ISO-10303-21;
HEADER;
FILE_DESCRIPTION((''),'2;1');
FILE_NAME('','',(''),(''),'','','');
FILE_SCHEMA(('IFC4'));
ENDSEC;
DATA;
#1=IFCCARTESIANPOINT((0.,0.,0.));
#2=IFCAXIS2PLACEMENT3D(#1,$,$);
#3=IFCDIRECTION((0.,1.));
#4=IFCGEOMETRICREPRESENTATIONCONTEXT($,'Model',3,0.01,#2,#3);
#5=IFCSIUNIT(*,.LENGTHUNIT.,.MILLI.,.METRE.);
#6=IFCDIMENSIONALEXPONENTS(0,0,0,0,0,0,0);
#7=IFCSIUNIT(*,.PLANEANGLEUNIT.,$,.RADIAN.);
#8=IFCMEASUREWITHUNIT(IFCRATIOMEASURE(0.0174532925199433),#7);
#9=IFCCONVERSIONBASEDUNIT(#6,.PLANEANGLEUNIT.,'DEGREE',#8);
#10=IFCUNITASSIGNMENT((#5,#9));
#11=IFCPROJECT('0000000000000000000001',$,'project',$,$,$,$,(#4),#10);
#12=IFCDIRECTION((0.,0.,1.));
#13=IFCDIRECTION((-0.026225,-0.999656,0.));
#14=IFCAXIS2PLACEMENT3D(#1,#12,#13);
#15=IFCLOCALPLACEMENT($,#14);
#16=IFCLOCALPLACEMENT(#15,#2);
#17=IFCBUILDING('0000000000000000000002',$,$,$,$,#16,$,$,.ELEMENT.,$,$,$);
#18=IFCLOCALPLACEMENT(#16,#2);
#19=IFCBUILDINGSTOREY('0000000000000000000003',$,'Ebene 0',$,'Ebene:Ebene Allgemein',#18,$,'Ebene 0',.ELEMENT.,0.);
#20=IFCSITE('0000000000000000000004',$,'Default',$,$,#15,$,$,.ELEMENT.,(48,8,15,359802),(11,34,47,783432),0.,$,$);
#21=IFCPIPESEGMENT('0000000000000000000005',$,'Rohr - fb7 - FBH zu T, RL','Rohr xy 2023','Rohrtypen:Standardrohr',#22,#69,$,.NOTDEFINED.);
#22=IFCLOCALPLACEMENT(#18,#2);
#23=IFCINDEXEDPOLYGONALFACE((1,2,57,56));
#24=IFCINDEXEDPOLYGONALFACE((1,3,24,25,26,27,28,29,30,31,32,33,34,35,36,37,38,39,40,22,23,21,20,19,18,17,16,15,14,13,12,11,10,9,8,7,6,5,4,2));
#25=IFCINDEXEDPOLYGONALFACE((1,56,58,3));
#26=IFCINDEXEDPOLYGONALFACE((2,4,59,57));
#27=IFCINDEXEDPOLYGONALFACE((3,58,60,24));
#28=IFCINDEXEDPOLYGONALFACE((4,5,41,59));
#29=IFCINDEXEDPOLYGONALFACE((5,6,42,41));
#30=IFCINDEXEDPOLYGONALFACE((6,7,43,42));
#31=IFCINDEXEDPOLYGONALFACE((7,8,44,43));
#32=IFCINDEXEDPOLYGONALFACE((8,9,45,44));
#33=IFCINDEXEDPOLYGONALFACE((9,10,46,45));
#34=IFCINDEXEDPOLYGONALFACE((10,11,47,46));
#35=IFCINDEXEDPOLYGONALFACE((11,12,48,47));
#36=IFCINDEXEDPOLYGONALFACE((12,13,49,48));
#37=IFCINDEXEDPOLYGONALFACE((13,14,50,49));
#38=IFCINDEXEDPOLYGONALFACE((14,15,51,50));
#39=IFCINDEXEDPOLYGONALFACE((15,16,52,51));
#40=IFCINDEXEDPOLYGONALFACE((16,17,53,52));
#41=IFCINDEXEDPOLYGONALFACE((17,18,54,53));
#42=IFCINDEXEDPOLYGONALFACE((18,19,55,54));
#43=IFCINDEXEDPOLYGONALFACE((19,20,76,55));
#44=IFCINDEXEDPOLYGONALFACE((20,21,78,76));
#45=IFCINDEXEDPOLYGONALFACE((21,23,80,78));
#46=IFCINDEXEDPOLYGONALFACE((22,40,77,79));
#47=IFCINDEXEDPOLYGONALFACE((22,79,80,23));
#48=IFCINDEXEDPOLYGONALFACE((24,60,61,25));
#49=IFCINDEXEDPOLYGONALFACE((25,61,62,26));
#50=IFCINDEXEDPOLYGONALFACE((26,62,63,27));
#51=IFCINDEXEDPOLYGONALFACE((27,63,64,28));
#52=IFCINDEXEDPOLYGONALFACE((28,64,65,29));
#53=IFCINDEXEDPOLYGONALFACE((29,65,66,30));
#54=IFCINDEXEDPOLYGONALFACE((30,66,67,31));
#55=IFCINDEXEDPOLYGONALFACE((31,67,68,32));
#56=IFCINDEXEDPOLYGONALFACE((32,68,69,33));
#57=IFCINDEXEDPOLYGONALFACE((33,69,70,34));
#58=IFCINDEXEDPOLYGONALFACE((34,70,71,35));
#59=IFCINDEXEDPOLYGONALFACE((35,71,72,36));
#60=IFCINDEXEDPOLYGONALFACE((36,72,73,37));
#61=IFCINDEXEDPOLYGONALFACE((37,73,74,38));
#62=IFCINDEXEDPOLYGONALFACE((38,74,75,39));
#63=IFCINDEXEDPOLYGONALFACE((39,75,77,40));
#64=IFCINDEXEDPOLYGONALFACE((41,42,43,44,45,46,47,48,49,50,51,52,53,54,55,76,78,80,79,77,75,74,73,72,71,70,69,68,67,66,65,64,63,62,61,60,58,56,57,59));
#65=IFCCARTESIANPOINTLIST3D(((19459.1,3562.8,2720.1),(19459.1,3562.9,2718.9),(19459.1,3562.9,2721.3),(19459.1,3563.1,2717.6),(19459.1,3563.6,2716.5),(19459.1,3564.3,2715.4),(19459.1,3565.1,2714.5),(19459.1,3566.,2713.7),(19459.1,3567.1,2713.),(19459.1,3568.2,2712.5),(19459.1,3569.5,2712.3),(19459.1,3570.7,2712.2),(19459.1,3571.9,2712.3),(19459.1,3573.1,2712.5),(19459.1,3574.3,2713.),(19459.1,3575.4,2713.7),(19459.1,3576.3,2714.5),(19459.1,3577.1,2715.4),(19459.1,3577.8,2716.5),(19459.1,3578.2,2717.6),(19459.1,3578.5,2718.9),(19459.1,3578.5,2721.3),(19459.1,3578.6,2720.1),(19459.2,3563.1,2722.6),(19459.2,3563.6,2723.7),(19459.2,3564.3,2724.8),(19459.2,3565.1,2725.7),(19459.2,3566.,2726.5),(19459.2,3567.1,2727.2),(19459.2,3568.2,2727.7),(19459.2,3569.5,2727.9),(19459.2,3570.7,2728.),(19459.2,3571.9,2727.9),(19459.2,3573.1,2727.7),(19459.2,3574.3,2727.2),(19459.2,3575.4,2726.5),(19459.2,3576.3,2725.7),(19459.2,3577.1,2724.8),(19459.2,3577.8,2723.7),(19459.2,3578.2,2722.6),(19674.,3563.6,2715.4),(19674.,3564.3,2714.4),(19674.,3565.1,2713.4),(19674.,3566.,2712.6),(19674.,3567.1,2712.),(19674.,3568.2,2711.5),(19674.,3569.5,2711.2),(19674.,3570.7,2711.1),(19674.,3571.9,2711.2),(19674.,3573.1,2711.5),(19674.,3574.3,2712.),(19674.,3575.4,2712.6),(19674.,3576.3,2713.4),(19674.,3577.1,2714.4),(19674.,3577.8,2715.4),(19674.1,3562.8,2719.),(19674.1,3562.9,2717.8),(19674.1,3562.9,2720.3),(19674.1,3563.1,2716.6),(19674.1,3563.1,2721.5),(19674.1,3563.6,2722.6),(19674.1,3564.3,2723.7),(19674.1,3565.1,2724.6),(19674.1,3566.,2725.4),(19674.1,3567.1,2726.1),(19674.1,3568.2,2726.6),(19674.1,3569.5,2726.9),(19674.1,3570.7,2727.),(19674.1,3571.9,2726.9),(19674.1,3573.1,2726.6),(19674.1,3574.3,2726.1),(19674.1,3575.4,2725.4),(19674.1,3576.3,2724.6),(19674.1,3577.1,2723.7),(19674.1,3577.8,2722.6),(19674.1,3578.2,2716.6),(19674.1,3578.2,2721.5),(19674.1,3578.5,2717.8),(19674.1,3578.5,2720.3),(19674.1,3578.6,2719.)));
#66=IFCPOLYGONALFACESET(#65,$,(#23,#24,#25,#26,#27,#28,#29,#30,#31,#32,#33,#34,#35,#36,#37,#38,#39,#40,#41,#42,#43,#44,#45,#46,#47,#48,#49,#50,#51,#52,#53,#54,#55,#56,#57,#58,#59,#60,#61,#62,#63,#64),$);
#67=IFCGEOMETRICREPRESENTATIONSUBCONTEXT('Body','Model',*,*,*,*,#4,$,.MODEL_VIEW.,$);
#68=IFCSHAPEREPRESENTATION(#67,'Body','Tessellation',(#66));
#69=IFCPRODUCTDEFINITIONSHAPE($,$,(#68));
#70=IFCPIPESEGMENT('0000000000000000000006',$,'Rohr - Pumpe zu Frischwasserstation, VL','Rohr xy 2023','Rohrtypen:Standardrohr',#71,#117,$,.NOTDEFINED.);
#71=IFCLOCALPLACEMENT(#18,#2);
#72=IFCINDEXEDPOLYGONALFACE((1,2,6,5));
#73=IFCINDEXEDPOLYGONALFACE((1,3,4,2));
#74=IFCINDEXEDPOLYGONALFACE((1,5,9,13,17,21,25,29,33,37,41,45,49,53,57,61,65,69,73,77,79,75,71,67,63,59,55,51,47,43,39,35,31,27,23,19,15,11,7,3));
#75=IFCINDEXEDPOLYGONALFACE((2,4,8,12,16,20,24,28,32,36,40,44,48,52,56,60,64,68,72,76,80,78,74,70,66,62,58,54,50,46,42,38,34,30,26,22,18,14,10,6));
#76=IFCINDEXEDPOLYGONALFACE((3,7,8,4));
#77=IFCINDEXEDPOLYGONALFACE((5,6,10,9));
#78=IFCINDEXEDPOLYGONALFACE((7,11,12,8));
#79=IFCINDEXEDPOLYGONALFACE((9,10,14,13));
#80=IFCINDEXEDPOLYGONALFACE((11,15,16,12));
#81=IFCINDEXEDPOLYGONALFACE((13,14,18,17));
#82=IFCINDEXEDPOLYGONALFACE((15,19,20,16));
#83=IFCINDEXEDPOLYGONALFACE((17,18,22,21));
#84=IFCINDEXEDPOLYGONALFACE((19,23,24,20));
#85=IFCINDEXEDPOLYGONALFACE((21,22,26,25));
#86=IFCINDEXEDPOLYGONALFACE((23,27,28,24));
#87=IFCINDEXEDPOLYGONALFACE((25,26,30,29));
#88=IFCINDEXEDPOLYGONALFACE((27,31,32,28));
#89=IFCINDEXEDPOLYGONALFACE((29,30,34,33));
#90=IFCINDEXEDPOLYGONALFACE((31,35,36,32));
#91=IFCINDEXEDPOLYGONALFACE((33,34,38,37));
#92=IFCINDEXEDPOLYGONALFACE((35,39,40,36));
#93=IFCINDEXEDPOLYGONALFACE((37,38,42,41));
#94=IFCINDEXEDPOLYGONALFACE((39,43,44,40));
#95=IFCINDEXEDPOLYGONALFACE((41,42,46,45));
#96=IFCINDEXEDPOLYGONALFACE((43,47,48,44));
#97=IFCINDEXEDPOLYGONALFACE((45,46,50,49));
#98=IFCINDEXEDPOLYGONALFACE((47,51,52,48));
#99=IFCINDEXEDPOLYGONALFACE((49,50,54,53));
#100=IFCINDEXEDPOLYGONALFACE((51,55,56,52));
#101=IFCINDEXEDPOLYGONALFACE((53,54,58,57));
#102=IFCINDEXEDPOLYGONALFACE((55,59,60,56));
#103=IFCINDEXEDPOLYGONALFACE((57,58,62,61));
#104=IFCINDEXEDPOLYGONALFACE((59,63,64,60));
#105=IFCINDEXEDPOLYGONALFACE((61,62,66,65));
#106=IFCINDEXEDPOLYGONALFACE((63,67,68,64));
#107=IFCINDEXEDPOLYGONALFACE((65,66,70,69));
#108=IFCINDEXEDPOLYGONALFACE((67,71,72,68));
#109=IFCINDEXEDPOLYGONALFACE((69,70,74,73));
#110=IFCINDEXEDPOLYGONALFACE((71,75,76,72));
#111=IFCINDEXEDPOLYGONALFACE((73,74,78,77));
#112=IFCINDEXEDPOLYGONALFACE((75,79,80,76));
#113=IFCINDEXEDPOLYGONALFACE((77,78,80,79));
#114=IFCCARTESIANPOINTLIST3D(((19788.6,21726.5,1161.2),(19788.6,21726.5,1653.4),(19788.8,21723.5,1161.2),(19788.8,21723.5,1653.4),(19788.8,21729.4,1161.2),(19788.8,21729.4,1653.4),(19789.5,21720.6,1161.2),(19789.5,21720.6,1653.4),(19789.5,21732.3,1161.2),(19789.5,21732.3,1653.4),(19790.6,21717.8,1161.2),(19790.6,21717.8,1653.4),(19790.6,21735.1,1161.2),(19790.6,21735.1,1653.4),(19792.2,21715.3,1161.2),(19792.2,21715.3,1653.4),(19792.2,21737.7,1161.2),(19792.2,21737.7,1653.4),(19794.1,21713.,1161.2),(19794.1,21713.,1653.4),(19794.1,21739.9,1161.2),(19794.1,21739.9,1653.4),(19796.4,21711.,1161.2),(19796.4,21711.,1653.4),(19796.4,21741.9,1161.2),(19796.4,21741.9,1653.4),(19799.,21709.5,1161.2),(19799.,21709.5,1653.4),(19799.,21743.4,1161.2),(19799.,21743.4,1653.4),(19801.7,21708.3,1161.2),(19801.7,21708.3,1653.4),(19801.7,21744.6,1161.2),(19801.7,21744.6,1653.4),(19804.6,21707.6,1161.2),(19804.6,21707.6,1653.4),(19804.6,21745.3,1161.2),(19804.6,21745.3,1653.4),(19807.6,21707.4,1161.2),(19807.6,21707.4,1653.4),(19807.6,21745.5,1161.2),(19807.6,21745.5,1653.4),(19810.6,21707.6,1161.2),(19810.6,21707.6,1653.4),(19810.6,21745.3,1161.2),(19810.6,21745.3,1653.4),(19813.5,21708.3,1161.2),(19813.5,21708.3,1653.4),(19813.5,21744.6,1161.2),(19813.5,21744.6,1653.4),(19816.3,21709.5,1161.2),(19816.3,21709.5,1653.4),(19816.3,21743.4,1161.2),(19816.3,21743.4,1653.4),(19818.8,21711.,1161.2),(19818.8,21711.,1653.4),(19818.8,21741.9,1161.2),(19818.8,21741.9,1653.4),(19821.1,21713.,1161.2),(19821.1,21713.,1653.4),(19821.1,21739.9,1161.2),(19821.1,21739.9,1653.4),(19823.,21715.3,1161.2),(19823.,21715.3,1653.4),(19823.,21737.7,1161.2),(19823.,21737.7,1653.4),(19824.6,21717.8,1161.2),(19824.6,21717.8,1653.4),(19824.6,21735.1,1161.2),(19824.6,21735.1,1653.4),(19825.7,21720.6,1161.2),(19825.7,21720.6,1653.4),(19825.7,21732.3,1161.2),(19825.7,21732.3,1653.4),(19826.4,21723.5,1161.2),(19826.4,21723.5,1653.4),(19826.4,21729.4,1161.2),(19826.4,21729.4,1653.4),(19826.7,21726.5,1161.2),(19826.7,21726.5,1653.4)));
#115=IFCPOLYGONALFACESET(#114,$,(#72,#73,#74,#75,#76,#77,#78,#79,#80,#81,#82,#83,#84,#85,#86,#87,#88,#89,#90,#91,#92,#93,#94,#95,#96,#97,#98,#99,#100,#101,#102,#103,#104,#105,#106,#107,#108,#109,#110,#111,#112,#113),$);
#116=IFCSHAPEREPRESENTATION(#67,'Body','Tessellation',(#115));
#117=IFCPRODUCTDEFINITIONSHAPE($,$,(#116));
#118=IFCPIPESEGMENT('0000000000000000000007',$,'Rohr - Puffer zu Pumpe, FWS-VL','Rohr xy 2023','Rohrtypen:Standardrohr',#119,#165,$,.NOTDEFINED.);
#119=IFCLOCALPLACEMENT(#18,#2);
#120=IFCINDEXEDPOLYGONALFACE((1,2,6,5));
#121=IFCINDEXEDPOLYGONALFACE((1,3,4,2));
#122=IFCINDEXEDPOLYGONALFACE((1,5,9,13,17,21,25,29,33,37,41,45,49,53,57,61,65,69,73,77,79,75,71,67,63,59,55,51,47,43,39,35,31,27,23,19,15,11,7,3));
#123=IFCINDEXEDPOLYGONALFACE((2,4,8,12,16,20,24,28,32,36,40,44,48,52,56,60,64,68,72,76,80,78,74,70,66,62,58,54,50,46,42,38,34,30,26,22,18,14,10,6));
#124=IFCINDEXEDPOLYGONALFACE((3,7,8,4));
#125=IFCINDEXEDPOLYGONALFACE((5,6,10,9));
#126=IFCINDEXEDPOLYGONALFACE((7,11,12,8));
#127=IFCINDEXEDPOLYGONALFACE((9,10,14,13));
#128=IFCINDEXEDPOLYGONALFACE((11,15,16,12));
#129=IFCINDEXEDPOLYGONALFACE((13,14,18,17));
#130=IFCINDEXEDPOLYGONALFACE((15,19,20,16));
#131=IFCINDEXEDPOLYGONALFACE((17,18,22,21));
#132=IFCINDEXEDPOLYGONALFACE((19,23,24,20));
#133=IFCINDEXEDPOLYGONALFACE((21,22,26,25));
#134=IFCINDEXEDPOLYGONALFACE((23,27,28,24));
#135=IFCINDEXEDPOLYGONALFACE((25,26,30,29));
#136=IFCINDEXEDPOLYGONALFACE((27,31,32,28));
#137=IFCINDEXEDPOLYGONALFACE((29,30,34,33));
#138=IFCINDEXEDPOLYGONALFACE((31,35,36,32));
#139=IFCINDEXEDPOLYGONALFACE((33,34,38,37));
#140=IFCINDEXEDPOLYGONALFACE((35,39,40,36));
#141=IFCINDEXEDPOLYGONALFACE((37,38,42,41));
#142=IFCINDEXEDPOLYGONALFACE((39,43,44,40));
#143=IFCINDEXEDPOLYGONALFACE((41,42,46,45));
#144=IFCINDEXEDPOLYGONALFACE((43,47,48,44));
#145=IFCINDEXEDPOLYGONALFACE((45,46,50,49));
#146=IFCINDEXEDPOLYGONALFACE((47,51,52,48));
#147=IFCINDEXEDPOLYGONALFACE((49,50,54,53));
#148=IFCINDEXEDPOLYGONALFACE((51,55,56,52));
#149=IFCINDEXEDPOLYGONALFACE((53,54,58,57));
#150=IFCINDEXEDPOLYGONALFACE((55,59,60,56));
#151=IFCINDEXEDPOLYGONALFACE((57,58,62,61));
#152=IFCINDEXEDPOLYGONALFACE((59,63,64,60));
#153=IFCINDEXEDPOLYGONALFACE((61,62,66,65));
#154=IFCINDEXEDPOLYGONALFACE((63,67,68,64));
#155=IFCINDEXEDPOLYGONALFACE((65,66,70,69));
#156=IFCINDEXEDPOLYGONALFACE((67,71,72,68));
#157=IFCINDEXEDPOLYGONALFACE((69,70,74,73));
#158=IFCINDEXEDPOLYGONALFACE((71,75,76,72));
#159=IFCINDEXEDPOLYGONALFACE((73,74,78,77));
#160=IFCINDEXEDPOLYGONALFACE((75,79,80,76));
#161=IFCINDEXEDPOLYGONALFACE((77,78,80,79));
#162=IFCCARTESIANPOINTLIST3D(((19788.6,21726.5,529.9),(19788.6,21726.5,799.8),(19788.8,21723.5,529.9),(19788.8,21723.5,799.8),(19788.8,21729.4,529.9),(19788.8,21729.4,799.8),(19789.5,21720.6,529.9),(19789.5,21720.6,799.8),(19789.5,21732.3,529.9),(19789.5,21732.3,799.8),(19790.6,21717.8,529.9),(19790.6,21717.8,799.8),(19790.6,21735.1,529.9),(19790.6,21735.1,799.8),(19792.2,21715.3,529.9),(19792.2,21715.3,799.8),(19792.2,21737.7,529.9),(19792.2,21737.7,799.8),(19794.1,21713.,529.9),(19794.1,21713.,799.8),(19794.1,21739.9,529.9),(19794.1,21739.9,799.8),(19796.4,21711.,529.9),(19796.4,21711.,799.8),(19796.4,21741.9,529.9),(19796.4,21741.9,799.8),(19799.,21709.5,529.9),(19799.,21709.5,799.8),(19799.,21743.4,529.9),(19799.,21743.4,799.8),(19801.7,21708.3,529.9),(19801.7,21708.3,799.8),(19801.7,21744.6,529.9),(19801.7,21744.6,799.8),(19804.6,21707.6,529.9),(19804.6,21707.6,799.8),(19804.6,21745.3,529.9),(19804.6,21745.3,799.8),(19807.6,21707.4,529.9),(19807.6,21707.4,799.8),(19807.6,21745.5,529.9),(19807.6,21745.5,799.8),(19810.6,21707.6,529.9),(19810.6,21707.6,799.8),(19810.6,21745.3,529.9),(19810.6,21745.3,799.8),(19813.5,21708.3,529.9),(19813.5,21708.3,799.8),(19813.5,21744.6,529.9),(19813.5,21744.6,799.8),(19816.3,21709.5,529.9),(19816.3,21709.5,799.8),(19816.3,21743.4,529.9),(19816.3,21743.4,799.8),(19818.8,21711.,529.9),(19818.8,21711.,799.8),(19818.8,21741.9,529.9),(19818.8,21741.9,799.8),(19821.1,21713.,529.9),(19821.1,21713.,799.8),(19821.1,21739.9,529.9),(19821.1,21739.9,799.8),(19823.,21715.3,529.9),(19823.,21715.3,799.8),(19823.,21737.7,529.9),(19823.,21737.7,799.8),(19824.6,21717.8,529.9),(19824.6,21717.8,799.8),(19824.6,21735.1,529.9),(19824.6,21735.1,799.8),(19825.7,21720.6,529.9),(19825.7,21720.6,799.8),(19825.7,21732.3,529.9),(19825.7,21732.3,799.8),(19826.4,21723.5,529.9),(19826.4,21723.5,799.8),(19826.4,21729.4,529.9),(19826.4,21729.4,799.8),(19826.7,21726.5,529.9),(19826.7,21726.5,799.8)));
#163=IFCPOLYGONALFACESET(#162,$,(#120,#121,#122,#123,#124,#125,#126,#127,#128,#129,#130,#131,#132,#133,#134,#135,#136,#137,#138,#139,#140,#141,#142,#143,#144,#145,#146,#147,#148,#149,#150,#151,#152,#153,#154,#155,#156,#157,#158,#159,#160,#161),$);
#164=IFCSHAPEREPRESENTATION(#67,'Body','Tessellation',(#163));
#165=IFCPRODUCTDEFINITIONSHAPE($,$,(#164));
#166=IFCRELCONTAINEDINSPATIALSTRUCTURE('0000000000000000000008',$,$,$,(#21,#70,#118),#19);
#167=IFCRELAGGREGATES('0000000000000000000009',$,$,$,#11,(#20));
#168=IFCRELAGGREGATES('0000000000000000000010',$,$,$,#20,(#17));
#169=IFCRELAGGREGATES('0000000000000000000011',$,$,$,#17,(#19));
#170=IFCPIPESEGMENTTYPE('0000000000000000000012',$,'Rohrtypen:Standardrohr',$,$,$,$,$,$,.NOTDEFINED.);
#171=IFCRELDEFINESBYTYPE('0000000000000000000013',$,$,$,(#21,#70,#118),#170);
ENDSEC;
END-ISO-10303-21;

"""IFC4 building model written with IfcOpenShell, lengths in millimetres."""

from ifc_helpers import new_model, entity, si_unit, converted_unit, direction, frame, origin, place, context, subcontext, project, spatial, indexed_curve, outline, extrude, type_object, element, save


model = new_model("IFC4")

# Units and contexts
model_context = context("Model", 3, precision=0.01, world=origin(), true_north=direction((0.0, 1.0)))
body_context = subcontext(model_context, "Body", "Model", "MODEL_VIEW")
ifc_project = project(units=[si_unit("LENGTHUNIT", "METRE", prefix="MILLI"), converted_unit("PLANEANGLEUNIT", "DEGREE", entity("IfcRatioMeasure", 0.0174532925199433), si_unit("PLANEANGLEUNIT", "RADIAN"), dimensions=[0, 0, 0, 0, 0, 0, 0])], contexts=[model_context])

# Site, building, storey
site_placement = place(None, frame((0.0, 0.0, 0.0), z_axis=(0.0, 0.0, 1.0), x_axis=(-0.026225, -0.999656, 0.0)))
site = spatial("IfcSite", under=ifc_project, at=site_placement, Name="Default", CompositionType="ELEMENT", RefLatitude=(48, 8, 15, 359802), RefLongitude=(11, 34, 47, 783432), RefElevation=0.0)
building_placement = place(site_placement, origin())
building = spatial("IfcBuilding", under=site, at=building_placement, CompositionType="ELEMENT")
storey_placement = place(building_placement, origin())
storey = spatial("IfcBuildingStorey", under=building, at=storey_placement, Name="Ebene 0", ObjectType="Ebene:Ebene Allgemein", LongName="Ebene 0", CompositionType="ELEMENT", Elevation=0.0)

# Pipe segments
pipe_segment_type = type_object("IfcPipeSegmentType", Name="Rohrtypen:Standardrohr", PredefinedType="NOTDEFINED")
pipe_segment_1_placement = place(storey_placement, origin())
element("IfcPipeSegment", 1, at=pipe_segment_1_placement, inside=storey, type_object=pipe_segment_type, Name="Rohr - fb7 - FBH zu T, RL", Description="Rohr xy 2023", ObjectType="Rohrtypen:Standardrohr", PredefinedType="NOTDEFINED", context=body_context, shape_type="SweptSolid", body=[
    extrude(outline(indexed_curve([(7.9, 0.0), (7.8, 1.2), (7.6, 2.5), (7.1, 3.6), (6.4, 4.7), (5.6, 5.6), (4.7, 6.4), (3.6, 7.1), (2.5, 7.6), (1.2, 7.8), (0.0, 7.9), (-1.2, 7.8), (-2.5, 7.6), (-3.6, 7.1), (-4.7, 6.4), (-5.6, 5.6), (-6.4, 4.7), (-7.1, 3.6), (-7.6, 2.5), (-7.8, 1.2), (-7.9, 0.0), (-7.8, -1.2), (-7.6, -2.5), (-7.1, -3.6), (-6.4, -4.7), (-5.6, -5.6), (-4.7, -6.4), (-3.6, -7.1), (-2.5, -7.6), (-1.2, -7.8), (0.0, -7.9), (1.2, -7.8), (2.5, -7.6), (3.6, -7.1), (4.7, -6.4), (5.6, -5.6), (6.4, -4.7), (7.1, -3.6), (7.6, -2.5), (7.8, -1.2), (7.9, 0.0)], self_intersect=False)), frame((19674.1, 3570.7, 2719.0), z_axis=(-0.999988, 0.0, 0.005), x_axis=(0.0, 1.0, 0.0)), (0.0, 0.0, 1.0), 214.9),
])
pipe_segment_2_placement = place(storey_placement, origin())
element("IfcPipeSegment", 2, at=pipe_segment_2_placement, inside=storey, type_object=pipe_segment_type, Name="Rohr - Pumpe zu Frischwasserstation, VL", Description="Rohr xy 2023", ObjectType="Rohrtypen:Standardrohr", PredefinedType="NOTDEFINED", context=body_context, shape_type="SweptSolid", body=[
    extrude(outline(indexed_curve([(19.1, 0.0), (18.8, 3.0), (18.1, 5.9), (17.0, 8.6), (15.4, 11.2), (13.5, 13.5), (11.2, 15.4), (8.6, 17.0), (5.9, 18.1), (3.0, 18.8), (0.0, 19.0), (-3.0, 18.8), (-5.9, 18.1), (-8.6, 17.0), (-11.2, 15.4), (-13.5, 13.5), (-15.4, 11.2), (-17.0, 8.6), (-18.1, 5.9), (-18.8, 3.0), (-19.1, 0.0), (-18.8, -3.0), (-18.1, -5.9), (-17.0, -8.6), (-15.4, -11.2), (-13.5, -13.5), (-11.2, -15.4), (-8.6, -17.0), (-5.9, -18.1), (-3.0, -18.8), (0.0, -19.0), (3.0, -18.8), (5.9, -18.1), (8.6, -17.0), (11.2, -15.4), (13.5, -13.5), (15.4, -11.2), (17.0, -8.6), (18.1, -5.9), (18.8, -3.0), (19.1, 0.0)], self_intersect=False)), frame((19807.6, 21726.5, 1161.2), z_axis=(0.000002, 0.000002, 1.0), x_axis=(-1.0, 0.0, 0.000002)), (0.0, 0.0, 1.0), 492.1),
])
pipe_segment_3_placement = place(storey_placement, origin())
element("IfcPipeSegment", 3, at=pipe_segment_3_placement, inside=storey, type_object=pipe_segment_type, Name="Rohr - Puffer zu Pumpe, FWS-VL", Description="Rohr xy 2023", ObjectType="Rohrtypen:Standardrohr", PredefinedType="NOTDEFINED", context=body_context, shape_type="SweptSolid", body=[
    extrude(outline(indexed_curve([(19.1, 0.0), (18.8, 3.0), (18.1, 5.9), (17.0, 8.6), (15.4, 11.2), (13.5, 13.5), (11.2, 15.4), (8.6, 17.0), (5.9, 18.1), (3.0, 18.8), (0.0, 19.0), (-3.0, 18.8), (-5.9, 18.1), (-8.6, 17.0), (-11.2, 15.4), (-13.5, 13.5), (-15.4, 11.2), (-17.0, 8.6), (-18.1, 5.9), (-18.8, 3.0), (-19.1, 0.0), (-18.8, -3.0), (-18.1, -5.9), (-17.0, -8.6), (-15.4, -11.2), (-13.5, -13.5), (-11.2, -15.4), (-8.6, -17.0), (-5.9, -18.1), (-3.0, -18.8), (0.0, -19.0), (3.0, -18.8), (5.9, -18.1), (8.6, -17.0), (11.2, -15.4), (13.5, -13.5), (15.4, -11.2), (17.0, -8.6), (18.1, -5.9), (18.8, -3.0), (19.1, 0.0)], self_intersect=False)), frame((19807.6, 21726.5, 529.9), z_axis=(0.000002, 0.000002, 1.0), x_axis=(-1.0, 0.0, 0.000002)), (0.0, 0.0, 1.0), 269.9),
])

save(model, "model.ifc")
